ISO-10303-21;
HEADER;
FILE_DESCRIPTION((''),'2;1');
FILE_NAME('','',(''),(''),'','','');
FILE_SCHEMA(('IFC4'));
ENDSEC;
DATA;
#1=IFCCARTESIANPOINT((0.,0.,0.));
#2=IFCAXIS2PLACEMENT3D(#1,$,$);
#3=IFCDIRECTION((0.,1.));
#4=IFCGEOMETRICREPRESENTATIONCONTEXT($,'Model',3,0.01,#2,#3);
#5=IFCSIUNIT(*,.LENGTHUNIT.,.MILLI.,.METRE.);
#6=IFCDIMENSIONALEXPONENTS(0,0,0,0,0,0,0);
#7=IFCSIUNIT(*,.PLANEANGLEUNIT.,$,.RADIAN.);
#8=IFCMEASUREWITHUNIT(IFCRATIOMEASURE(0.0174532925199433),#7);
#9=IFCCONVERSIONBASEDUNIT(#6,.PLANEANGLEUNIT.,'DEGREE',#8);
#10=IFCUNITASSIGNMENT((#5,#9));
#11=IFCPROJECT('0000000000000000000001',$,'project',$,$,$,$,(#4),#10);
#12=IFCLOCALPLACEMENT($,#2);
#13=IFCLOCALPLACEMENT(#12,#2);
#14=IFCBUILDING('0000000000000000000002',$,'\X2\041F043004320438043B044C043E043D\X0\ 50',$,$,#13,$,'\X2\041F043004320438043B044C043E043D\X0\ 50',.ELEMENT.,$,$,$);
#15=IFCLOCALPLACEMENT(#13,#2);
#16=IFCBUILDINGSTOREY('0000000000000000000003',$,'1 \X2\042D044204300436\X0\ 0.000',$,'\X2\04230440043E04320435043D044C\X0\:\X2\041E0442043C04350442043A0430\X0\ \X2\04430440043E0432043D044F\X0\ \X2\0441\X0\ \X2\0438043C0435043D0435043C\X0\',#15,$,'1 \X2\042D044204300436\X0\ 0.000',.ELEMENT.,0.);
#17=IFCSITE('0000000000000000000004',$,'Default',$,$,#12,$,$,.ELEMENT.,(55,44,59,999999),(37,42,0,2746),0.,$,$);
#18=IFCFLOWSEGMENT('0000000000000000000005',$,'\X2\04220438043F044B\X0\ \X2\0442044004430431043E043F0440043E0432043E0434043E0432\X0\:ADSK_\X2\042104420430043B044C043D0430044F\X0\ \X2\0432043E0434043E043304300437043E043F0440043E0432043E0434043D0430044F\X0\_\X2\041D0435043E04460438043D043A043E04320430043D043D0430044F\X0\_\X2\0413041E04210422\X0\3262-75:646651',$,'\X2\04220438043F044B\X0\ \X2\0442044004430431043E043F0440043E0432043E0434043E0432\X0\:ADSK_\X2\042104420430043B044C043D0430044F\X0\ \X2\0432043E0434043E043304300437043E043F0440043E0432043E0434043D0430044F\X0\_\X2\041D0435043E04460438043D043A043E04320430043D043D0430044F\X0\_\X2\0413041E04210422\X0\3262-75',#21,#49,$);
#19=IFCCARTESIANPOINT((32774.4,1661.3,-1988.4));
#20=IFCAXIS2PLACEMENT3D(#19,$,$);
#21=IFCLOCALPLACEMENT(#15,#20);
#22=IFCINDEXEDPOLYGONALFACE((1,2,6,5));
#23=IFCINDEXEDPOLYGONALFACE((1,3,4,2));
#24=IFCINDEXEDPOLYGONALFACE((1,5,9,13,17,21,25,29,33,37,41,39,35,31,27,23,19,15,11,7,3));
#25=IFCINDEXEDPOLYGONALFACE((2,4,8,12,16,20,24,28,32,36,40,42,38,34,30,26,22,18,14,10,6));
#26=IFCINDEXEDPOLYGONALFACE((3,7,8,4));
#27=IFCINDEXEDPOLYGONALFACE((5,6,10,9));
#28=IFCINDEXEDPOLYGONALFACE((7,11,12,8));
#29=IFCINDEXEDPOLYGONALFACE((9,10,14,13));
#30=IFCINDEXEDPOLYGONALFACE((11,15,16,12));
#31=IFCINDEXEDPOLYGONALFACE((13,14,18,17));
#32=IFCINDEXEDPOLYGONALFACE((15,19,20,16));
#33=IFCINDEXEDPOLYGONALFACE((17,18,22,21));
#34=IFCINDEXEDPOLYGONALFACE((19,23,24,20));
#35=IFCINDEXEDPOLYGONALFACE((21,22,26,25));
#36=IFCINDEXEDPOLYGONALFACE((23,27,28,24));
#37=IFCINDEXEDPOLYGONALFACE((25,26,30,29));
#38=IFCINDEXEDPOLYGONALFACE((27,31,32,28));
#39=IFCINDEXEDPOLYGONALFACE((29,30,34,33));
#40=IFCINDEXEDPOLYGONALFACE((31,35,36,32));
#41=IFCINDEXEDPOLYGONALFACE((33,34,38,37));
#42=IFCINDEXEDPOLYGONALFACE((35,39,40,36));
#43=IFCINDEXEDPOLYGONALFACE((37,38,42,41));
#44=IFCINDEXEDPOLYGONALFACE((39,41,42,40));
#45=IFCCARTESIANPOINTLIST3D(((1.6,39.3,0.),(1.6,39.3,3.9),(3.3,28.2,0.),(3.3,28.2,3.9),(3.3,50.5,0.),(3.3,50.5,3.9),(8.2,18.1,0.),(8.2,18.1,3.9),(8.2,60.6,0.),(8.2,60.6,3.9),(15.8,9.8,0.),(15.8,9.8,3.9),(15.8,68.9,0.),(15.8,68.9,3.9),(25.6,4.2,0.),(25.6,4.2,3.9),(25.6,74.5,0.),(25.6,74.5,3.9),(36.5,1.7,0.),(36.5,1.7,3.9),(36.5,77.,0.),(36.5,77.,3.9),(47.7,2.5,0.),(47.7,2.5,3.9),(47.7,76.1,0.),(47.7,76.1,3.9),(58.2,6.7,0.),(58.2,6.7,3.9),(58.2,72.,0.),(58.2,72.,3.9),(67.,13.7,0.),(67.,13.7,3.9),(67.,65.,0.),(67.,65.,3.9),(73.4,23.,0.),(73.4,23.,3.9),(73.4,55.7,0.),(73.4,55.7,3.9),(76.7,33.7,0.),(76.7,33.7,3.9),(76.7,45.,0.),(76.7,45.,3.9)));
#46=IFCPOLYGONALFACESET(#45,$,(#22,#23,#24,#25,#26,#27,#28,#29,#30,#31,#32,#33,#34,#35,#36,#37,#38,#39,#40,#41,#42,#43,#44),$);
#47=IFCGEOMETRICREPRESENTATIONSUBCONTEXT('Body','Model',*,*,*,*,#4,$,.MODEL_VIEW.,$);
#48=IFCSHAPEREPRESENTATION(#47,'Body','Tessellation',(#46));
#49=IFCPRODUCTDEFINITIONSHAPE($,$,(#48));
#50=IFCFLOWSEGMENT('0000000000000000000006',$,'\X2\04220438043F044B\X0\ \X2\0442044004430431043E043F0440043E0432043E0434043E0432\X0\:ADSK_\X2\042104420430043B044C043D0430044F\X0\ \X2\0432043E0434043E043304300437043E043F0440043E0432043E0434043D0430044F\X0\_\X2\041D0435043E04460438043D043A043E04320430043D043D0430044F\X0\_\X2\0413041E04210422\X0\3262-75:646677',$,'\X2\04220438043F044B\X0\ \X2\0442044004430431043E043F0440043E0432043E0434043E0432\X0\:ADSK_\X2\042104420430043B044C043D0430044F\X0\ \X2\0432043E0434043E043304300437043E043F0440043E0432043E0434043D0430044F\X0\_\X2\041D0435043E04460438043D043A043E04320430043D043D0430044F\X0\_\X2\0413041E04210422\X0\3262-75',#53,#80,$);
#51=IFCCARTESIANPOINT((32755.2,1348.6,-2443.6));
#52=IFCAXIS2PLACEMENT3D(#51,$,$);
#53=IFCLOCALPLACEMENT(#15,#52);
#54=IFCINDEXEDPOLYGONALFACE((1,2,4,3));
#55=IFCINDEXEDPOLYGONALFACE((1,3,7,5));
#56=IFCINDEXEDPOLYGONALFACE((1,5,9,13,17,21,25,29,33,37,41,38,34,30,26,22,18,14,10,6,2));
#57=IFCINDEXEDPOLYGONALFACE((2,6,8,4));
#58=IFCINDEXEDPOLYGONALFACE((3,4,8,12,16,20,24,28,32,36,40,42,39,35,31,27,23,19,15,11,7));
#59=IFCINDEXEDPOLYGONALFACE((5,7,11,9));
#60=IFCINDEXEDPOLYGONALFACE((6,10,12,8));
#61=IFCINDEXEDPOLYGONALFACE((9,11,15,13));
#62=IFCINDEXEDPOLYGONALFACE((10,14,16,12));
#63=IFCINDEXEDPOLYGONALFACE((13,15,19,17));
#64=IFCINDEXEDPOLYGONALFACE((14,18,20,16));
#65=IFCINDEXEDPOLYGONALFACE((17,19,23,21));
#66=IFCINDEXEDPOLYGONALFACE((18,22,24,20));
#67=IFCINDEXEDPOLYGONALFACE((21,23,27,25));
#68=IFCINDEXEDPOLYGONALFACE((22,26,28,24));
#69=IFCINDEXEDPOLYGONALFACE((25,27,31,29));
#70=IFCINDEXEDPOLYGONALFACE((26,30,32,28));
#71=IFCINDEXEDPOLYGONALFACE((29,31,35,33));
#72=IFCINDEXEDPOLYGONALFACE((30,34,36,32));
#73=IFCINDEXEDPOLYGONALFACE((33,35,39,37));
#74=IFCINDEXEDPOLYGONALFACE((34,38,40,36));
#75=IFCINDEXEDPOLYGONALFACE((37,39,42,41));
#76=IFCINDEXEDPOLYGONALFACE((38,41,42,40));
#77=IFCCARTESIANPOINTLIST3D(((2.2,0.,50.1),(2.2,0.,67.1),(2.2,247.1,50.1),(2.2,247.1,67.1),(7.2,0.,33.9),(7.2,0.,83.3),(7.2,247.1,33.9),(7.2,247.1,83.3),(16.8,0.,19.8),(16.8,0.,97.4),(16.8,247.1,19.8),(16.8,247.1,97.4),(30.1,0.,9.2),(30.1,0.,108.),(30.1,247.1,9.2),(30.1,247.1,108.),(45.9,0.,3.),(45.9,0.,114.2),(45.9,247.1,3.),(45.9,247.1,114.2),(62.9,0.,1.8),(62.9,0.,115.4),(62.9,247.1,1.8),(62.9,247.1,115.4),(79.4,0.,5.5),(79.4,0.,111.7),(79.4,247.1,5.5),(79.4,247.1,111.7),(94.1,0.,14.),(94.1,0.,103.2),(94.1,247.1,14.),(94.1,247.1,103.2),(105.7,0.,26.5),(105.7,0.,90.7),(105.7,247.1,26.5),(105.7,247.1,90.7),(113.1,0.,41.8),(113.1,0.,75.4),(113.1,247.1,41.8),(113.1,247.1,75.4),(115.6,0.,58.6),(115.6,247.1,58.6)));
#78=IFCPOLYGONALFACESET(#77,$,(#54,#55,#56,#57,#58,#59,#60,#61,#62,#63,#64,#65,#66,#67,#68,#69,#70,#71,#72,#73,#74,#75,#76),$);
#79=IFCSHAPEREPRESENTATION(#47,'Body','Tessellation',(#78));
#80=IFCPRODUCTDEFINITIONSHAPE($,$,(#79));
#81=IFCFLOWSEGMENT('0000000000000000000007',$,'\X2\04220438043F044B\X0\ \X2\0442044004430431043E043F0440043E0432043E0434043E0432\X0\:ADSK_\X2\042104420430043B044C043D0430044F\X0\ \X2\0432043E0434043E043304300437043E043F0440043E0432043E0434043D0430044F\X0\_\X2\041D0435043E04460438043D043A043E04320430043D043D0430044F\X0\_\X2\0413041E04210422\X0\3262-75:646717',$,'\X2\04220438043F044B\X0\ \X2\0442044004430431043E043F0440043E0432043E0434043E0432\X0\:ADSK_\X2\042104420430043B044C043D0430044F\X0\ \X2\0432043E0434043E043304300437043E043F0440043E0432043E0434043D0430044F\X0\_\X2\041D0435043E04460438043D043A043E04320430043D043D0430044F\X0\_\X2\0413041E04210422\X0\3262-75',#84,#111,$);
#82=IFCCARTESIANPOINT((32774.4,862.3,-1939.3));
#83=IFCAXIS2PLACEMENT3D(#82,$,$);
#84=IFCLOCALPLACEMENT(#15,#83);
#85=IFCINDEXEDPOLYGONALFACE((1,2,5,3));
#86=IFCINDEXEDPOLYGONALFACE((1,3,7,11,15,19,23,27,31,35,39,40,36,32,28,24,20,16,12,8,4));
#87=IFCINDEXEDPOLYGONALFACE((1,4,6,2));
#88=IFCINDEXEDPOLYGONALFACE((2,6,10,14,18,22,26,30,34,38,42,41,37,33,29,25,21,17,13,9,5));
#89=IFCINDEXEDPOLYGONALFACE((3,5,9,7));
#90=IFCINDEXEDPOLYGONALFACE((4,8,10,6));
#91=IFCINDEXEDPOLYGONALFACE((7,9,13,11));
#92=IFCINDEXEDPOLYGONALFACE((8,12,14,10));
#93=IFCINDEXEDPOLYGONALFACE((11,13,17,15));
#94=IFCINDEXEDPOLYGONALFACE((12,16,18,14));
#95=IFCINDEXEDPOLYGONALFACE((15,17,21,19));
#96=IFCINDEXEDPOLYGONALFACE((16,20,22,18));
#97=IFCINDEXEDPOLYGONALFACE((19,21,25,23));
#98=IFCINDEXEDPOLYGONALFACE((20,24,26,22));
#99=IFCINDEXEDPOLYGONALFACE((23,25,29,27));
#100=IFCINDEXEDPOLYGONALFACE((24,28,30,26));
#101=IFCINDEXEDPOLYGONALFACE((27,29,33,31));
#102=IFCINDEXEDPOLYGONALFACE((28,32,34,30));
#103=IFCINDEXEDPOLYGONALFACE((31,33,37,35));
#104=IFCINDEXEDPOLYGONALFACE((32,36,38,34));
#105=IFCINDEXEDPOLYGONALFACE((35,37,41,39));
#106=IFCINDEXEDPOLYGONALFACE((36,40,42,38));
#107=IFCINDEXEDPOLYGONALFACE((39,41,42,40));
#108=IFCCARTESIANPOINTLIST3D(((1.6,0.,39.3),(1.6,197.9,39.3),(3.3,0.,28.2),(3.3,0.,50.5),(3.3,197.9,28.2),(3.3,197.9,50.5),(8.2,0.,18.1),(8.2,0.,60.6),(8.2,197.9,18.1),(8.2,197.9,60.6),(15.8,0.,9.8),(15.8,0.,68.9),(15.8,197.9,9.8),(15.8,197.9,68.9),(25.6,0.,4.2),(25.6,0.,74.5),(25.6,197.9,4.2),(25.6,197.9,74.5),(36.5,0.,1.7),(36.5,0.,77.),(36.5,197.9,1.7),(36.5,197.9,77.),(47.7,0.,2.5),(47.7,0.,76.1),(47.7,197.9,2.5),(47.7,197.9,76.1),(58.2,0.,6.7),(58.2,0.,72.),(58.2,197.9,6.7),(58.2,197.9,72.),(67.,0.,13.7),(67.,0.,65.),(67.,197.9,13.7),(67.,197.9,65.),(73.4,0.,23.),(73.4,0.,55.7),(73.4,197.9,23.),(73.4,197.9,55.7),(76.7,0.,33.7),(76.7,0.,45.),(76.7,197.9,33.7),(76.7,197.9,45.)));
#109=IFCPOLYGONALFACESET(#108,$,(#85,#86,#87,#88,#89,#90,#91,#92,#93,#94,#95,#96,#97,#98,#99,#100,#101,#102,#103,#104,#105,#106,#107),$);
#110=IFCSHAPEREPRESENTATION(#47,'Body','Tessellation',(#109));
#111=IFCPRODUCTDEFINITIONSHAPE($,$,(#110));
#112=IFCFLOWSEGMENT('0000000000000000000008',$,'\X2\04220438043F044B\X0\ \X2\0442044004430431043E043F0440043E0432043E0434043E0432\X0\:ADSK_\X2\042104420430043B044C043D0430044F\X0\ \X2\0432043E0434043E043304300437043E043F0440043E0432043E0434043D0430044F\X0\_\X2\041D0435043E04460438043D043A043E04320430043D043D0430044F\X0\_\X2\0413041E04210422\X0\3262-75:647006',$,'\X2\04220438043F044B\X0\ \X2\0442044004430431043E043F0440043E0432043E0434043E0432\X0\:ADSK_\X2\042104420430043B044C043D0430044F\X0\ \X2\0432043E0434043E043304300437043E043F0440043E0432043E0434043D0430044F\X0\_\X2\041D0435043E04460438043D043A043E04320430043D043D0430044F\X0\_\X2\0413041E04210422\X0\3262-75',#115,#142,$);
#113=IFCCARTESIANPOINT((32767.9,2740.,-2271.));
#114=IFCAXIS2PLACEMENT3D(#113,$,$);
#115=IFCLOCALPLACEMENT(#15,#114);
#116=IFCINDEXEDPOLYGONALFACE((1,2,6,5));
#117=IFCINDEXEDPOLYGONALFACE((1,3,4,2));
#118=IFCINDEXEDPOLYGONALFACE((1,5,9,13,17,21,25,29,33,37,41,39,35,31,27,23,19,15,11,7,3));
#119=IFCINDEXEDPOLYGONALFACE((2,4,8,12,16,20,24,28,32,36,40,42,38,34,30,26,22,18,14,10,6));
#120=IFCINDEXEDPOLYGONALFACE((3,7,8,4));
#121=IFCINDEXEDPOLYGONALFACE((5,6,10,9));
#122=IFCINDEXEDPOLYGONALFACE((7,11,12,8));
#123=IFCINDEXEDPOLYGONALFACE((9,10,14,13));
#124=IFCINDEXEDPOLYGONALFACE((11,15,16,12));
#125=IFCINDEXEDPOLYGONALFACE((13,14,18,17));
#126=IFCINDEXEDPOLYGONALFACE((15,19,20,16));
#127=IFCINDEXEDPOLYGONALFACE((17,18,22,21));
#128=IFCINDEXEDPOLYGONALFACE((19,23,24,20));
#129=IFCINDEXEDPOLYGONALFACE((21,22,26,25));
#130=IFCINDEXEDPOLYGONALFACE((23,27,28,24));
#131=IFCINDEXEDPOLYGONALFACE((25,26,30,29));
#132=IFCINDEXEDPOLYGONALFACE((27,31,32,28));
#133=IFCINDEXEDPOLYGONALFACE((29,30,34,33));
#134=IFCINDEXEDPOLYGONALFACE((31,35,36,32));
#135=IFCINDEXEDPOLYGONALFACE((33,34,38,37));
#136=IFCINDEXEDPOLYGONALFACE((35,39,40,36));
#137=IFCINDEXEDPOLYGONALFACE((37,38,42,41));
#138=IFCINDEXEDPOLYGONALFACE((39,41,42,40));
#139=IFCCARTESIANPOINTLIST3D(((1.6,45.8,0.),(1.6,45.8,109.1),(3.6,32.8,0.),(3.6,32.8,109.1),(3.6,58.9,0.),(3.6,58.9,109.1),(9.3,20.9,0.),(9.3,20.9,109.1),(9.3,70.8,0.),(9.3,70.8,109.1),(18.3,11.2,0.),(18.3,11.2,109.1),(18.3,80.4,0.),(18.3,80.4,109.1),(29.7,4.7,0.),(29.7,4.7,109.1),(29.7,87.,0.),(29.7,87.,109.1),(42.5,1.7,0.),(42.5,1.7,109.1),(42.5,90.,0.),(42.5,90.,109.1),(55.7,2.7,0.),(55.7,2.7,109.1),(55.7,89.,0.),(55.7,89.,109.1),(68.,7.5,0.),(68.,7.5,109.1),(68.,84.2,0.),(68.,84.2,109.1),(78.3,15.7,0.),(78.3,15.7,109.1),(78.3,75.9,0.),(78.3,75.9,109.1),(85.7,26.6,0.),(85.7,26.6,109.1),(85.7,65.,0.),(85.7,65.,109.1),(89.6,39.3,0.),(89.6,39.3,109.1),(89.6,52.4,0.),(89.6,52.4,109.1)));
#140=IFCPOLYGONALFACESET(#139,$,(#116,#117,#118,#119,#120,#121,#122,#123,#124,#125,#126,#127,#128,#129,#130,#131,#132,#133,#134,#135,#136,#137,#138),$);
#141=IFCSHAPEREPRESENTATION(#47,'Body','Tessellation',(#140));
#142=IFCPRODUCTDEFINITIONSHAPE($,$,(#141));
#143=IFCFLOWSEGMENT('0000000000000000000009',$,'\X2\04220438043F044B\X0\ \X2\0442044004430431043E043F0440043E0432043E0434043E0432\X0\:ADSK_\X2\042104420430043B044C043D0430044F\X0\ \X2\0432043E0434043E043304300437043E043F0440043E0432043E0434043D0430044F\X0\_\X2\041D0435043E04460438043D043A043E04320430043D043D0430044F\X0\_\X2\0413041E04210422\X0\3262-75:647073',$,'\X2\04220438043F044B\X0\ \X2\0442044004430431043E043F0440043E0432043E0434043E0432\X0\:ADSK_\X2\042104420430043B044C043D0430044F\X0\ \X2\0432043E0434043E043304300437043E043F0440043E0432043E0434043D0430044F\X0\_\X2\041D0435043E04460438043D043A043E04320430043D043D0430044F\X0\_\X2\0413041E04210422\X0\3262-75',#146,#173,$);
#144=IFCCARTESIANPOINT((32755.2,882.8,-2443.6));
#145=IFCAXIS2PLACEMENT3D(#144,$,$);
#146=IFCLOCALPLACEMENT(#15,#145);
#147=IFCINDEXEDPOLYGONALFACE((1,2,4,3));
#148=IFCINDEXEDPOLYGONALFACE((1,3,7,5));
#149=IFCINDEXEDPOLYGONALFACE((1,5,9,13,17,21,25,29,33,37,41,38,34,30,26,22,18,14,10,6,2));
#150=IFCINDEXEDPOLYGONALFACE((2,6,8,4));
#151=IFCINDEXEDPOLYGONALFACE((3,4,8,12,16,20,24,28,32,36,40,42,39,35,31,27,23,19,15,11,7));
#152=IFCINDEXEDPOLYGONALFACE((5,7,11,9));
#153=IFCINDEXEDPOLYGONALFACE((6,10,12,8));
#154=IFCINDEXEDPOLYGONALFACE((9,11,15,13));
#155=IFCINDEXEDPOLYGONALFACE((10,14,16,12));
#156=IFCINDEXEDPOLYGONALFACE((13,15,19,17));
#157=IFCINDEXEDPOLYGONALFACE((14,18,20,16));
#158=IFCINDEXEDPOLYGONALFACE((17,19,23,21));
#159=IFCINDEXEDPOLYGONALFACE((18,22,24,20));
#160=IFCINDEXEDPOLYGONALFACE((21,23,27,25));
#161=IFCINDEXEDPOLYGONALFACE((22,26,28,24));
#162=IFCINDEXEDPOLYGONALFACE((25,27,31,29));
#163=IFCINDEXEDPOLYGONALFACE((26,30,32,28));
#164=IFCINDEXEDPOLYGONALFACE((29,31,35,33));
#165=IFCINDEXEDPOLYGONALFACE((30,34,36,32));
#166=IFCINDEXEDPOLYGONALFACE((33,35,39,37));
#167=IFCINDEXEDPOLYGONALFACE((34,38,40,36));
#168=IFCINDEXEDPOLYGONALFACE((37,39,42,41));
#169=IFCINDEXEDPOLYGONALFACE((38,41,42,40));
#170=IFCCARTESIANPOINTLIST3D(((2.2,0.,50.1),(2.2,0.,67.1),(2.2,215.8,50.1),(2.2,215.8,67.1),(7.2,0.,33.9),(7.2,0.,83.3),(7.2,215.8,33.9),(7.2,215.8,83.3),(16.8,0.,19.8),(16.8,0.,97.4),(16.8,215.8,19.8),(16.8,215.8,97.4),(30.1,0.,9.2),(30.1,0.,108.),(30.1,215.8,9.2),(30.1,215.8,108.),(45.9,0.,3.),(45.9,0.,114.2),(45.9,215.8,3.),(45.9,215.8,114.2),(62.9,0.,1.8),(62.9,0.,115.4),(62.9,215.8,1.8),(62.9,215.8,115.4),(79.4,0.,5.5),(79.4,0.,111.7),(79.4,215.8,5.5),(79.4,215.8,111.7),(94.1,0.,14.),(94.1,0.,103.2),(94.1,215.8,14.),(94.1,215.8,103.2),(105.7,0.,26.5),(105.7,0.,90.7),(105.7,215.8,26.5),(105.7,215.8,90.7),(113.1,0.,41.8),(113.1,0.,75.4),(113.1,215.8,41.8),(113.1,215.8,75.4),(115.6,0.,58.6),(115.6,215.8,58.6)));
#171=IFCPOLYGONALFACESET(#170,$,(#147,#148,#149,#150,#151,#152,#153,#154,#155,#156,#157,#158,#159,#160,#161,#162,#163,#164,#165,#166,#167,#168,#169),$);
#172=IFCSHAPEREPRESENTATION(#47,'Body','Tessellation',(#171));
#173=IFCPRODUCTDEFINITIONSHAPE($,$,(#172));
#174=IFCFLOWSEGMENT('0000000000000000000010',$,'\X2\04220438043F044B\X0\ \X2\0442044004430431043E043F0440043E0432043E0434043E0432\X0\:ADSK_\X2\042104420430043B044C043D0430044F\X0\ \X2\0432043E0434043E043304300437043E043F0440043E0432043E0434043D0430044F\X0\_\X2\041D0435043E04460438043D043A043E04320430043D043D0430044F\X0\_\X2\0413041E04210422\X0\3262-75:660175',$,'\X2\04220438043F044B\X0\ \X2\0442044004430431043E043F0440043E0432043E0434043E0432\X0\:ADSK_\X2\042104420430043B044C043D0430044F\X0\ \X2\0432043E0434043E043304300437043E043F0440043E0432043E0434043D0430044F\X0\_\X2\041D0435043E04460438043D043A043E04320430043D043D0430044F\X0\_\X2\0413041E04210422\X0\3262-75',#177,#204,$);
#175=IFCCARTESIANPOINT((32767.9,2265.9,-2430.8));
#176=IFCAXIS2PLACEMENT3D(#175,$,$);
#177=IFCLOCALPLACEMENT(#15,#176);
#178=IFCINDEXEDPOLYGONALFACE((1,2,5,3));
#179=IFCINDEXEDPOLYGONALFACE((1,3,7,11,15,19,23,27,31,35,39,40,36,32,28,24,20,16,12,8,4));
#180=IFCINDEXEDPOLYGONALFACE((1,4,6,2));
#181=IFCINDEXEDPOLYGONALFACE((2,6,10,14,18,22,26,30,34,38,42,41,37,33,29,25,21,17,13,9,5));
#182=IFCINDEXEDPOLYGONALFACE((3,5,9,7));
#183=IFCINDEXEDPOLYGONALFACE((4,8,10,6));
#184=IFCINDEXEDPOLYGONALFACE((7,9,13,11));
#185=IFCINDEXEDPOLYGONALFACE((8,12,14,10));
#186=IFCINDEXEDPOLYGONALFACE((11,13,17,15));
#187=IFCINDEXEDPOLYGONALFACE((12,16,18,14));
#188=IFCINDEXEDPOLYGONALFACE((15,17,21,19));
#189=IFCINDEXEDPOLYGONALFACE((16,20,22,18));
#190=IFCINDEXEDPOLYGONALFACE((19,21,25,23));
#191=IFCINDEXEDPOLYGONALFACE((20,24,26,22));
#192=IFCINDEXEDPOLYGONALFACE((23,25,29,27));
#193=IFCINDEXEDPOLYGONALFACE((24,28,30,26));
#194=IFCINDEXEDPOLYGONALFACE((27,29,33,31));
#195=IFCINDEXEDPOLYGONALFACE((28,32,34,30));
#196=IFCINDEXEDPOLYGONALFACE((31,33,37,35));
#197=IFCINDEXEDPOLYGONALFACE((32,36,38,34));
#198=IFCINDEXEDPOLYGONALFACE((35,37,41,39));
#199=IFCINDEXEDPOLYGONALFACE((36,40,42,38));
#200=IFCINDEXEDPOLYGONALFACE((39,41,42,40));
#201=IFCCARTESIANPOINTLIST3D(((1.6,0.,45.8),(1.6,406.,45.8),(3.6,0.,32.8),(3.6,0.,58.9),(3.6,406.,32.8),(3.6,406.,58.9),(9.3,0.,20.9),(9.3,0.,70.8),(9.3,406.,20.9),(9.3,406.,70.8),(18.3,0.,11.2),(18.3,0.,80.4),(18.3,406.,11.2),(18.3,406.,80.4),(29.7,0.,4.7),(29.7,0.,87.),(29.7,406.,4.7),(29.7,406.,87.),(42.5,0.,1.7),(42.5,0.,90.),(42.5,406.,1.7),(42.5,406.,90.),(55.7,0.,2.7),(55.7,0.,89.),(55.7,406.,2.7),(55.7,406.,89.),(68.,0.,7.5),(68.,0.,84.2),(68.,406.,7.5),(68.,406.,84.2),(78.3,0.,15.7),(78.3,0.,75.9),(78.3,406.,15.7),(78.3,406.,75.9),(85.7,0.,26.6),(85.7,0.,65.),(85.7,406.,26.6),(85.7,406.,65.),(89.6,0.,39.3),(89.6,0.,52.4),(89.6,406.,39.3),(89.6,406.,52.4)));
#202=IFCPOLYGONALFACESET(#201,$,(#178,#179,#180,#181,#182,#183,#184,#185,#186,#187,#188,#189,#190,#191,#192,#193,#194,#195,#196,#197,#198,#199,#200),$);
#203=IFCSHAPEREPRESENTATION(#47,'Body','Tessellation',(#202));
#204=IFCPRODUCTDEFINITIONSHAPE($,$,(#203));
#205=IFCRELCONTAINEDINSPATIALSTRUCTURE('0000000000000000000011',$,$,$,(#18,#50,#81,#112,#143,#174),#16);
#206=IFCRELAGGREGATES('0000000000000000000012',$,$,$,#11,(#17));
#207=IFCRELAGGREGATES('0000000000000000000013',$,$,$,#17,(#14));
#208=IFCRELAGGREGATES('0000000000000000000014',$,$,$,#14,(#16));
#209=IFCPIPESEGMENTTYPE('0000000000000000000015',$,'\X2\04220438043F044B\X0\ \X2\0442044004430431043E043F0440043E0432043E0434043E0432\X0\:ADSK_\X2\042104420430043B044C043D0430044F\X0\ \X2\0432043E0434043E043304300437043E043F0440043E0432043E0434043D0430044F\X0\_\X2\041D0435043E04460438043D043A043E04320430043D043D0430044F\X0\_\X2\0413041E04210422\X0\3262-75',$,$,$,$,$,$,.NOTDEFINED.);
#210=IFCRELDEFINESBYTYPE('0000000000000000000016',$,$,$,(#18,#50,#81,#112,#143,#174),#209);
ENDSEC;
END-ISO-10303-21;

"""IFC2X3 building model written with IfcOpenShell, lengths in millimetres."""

from ifc_helpers import new_model, entity, si_unit, converted_unit, direction, frame, frame_2d, origin, origin_2d_with_axis, place, context, subcontext, project, spatial, circle, extrude, type_object, element, save


model = new_model("IFC2X3")

# Units and contexts
model_context = context("Model", 3, precision=0.01, world=origin(), true_north=direction((0.0, 1.0)))
body_context = subcontext(model_context, "Body", "Model", "MODEL_VIEW")
ifc_project = project(units=[si_unit("LENGTHUNIT", "METRE", prefix="MILLI"), converted_unit("PLANEANGLEUNIT", "DEGREE", entity("IfcRatioMeasure", 0.0174532925199433), si_unit("PLANEANGLEUNIT", "RADIAN"), dimensions=[0, 0, 0, 0, 0, 0, 0])], contexts=[model_context])

# Site, building, storey
site_placement = place(None, origin())
site = spatial("IfcSite", under=ifc_project, at=site_placement, Name="Default", CompositionType="ELEMENT", RefLatitude=(55, 44, 59, 999999), RefLongitude=(37, 42, 0, 2746), RefElevation=0.0)
building_placement = place(site_placement, origin())
building = spatial("IfcBuilding", under=site, at=building_placement, Name="Павильон 50", LongName="Павильон 50", CompositionType="ELEMENT")
storey_placement = place(building_placement, origin())
storey = spatial("IfcBuildingStorey", under=building, at=storey_placement, Name="1 Этаж 0.000", ObjectType="Уровень:Отметка уровня с именем", LongName="1 Этаж 0.000", CompositionType="ELEMENT", Elevation=0.0)

# Flow segments
pipe_segment_type = type_object("IfcPipeSegmentType", Name="Типы трубопроводов:ADSK_Стальная водогазопроводная_Неоцинкованная_ГОСТ3262-75", PredefinedType="NOTDEFINED")
flow_segment_1_placement = place(storey_placement, frame((32774.4, 1661.3, -1988.4)))
element("IfcFlowSegment", 1, at=flow_segment_1_placement, inside=storey, type_object=pipe_segment_type, Name="Типы трубопроводов:ADSK_Стальная водогазопроводная_Неоцинкованная_ГОСТ3262-75:646651", ObjectType="Типы трубопроводов:ADSK_Стальная водогазопроводная_Неоцинкованная_ГОСТ3262-75", context=body_context, shape_type="SweptSolid", body=[
    extrude(circle(Radius=37.8, at=origin_2d_with_axis()), frame((39.3, 39.3, 0.0), z_axis=(0.0, 0.0, 1.0), x_axis=(-1.0, 0.0, 0.0)), (0.0, 0.0, 1.0), 3.9),
])
flow_segment_2_placement = place(storey_placement, frame((32755.2, 1348.6, -2443.6)))
element("IfcFlowSegment", 2, at=flow_segment_2_placement, inside=storey, type_object=pipe_segment_type, Name="Типы трубопроводов:ADSK_Стальная водогазопроводная_Неоцинкованная_ГОСТ3262-75:646677", ObjectType="Типы трубопроводов:ADSK_Стальная водогазопроводная_Неоцинкованная_ГОСТ3262-75", context=body_context, shape_type="SweptSolid", body=[
    extrude(circle(Radius=57.0, at=frame_2d((0.0, 0.0), x_axis=(1.0, 0.0))), frame((58.6, 0.0, 58.6), z_axis=(0.0, 1.0, 0.0), x_axis=(1.0, 0.0, 0.0)), (0.0, 0.0, 1.0), 247.1),
])
flow_segment_3_placement = place(storey_placement, frame((32774.4, 862.3, -1939.3)))
element("IfcFlowSegment", 3, at=flow_segment_3_placement, inside=storey, type_object=pipe_segment_type, Name="Типы трубопроводов:ADSK_Стальная водогазопроводная_Неоцинкованная_ГОСТ3262-75:646717", ObjectType="Типы трубопроводов:ADSK_Стальная водогазопроводная_Неоцинкованная_ГОСТ3262-75", context=body_context, shape_type="SweptSolid", body=[
    extrude(circle(Radius=37.8, at=origin_2d_with_axis()), frame((39.3, 0.0, 39.3), z_axis=(0.0, 1.0, 0.0), x_axis=(-1.0, 0.0, 0.0)), (0.0, 0.0, 1.0), 197.9),
])
flow_segment_4_placement = place(storey_placement, frame((32767.9, 2740.0, -2271.0)))
element("IfcFlowSegment", 4, at=flow_segment_4_placement, inside=storey, type_object=pipe_segment_type, Name="Типы трубопроводов:ADSK_Стальная водогазопроводная_Неоцинкованная_ГОСТ3262-75:647006", ObjectType="Типы трубопроводов:ADSK_Стальная водогазопроводная_Неоцинкованная_ГОСТ3262-75", context=body_context, shape_type="SweptSolid", body=[
    extrude(circle(Radius=44.2, at=frame_2d((0.0, 0.0), x_axis=(1.0, 0.0))), frame((45.8, 45.8, 0.0), z_axis=(0.0, 0.0, 1.0), x_axis=(-1.0, 0.0, 0.0)), (0.0, 0.0, 1.0), 109.1),
])
flow_segment_5_placement = place(storey_placement, frame((32755.2, 882.8, -2443.6)))
element("IfcFlowSegment", 5, at=flow_segment_5_placement, inside=storey, type_object=pipe_segment_type, Name="Типы трубопроводов:ADSK_Стальная водогазопроводная_Неоцинкованная_ГОСТ3262-75:647073", ObjectType="Типы трубопроводов:ADSK_Стальная водогазопроводная_Неоцинкованная_ГОСТ3262-75", context=body_context, shape_type="SweptSolid", body=[
    extrude(circle(Radius=57.0, at=origin_2d_with_axis()), frame((58.6, 0.0, 58.6), z_axis=(0.0, 1.0, 0.0), x_axis=(1.0, 0.0, 0.0)), (0.0, 0.0, 1.0), 215.8),
])
flow_segment_6_placement = place(storey_placement, frame((32767.9, 2265.9, -2430.8)))
element("IfcFlowSegment", 6, at=flow_segment_6_placement, inside=storey, type_object=pipe_segment_type, Name="Типы трубопроводов:ADSK_Стальная водогазопроводная_Неоцинкованная_ГОСТ3262-75:660175", ObjectType="Типы трубопроводов:ADSK_Стальная водогазопроводная_Неоцинкованная_ГОСТ3262-75", context=body_context, shape_type="SweptSolid", body=[
    extrude(circle(Radius=44.2, at=frame_2d((0.0, 0.0), x_axis=(1.0, 0.0))), frame((45.8, 0.0, 45.8), z_axis=(0.0, 1.0, 0.0), x_axis=(-1.0, 0.0, 0.0)), (0.0, 0.0, 1.0), 406.0),
])

save(model, "model.ifc")
